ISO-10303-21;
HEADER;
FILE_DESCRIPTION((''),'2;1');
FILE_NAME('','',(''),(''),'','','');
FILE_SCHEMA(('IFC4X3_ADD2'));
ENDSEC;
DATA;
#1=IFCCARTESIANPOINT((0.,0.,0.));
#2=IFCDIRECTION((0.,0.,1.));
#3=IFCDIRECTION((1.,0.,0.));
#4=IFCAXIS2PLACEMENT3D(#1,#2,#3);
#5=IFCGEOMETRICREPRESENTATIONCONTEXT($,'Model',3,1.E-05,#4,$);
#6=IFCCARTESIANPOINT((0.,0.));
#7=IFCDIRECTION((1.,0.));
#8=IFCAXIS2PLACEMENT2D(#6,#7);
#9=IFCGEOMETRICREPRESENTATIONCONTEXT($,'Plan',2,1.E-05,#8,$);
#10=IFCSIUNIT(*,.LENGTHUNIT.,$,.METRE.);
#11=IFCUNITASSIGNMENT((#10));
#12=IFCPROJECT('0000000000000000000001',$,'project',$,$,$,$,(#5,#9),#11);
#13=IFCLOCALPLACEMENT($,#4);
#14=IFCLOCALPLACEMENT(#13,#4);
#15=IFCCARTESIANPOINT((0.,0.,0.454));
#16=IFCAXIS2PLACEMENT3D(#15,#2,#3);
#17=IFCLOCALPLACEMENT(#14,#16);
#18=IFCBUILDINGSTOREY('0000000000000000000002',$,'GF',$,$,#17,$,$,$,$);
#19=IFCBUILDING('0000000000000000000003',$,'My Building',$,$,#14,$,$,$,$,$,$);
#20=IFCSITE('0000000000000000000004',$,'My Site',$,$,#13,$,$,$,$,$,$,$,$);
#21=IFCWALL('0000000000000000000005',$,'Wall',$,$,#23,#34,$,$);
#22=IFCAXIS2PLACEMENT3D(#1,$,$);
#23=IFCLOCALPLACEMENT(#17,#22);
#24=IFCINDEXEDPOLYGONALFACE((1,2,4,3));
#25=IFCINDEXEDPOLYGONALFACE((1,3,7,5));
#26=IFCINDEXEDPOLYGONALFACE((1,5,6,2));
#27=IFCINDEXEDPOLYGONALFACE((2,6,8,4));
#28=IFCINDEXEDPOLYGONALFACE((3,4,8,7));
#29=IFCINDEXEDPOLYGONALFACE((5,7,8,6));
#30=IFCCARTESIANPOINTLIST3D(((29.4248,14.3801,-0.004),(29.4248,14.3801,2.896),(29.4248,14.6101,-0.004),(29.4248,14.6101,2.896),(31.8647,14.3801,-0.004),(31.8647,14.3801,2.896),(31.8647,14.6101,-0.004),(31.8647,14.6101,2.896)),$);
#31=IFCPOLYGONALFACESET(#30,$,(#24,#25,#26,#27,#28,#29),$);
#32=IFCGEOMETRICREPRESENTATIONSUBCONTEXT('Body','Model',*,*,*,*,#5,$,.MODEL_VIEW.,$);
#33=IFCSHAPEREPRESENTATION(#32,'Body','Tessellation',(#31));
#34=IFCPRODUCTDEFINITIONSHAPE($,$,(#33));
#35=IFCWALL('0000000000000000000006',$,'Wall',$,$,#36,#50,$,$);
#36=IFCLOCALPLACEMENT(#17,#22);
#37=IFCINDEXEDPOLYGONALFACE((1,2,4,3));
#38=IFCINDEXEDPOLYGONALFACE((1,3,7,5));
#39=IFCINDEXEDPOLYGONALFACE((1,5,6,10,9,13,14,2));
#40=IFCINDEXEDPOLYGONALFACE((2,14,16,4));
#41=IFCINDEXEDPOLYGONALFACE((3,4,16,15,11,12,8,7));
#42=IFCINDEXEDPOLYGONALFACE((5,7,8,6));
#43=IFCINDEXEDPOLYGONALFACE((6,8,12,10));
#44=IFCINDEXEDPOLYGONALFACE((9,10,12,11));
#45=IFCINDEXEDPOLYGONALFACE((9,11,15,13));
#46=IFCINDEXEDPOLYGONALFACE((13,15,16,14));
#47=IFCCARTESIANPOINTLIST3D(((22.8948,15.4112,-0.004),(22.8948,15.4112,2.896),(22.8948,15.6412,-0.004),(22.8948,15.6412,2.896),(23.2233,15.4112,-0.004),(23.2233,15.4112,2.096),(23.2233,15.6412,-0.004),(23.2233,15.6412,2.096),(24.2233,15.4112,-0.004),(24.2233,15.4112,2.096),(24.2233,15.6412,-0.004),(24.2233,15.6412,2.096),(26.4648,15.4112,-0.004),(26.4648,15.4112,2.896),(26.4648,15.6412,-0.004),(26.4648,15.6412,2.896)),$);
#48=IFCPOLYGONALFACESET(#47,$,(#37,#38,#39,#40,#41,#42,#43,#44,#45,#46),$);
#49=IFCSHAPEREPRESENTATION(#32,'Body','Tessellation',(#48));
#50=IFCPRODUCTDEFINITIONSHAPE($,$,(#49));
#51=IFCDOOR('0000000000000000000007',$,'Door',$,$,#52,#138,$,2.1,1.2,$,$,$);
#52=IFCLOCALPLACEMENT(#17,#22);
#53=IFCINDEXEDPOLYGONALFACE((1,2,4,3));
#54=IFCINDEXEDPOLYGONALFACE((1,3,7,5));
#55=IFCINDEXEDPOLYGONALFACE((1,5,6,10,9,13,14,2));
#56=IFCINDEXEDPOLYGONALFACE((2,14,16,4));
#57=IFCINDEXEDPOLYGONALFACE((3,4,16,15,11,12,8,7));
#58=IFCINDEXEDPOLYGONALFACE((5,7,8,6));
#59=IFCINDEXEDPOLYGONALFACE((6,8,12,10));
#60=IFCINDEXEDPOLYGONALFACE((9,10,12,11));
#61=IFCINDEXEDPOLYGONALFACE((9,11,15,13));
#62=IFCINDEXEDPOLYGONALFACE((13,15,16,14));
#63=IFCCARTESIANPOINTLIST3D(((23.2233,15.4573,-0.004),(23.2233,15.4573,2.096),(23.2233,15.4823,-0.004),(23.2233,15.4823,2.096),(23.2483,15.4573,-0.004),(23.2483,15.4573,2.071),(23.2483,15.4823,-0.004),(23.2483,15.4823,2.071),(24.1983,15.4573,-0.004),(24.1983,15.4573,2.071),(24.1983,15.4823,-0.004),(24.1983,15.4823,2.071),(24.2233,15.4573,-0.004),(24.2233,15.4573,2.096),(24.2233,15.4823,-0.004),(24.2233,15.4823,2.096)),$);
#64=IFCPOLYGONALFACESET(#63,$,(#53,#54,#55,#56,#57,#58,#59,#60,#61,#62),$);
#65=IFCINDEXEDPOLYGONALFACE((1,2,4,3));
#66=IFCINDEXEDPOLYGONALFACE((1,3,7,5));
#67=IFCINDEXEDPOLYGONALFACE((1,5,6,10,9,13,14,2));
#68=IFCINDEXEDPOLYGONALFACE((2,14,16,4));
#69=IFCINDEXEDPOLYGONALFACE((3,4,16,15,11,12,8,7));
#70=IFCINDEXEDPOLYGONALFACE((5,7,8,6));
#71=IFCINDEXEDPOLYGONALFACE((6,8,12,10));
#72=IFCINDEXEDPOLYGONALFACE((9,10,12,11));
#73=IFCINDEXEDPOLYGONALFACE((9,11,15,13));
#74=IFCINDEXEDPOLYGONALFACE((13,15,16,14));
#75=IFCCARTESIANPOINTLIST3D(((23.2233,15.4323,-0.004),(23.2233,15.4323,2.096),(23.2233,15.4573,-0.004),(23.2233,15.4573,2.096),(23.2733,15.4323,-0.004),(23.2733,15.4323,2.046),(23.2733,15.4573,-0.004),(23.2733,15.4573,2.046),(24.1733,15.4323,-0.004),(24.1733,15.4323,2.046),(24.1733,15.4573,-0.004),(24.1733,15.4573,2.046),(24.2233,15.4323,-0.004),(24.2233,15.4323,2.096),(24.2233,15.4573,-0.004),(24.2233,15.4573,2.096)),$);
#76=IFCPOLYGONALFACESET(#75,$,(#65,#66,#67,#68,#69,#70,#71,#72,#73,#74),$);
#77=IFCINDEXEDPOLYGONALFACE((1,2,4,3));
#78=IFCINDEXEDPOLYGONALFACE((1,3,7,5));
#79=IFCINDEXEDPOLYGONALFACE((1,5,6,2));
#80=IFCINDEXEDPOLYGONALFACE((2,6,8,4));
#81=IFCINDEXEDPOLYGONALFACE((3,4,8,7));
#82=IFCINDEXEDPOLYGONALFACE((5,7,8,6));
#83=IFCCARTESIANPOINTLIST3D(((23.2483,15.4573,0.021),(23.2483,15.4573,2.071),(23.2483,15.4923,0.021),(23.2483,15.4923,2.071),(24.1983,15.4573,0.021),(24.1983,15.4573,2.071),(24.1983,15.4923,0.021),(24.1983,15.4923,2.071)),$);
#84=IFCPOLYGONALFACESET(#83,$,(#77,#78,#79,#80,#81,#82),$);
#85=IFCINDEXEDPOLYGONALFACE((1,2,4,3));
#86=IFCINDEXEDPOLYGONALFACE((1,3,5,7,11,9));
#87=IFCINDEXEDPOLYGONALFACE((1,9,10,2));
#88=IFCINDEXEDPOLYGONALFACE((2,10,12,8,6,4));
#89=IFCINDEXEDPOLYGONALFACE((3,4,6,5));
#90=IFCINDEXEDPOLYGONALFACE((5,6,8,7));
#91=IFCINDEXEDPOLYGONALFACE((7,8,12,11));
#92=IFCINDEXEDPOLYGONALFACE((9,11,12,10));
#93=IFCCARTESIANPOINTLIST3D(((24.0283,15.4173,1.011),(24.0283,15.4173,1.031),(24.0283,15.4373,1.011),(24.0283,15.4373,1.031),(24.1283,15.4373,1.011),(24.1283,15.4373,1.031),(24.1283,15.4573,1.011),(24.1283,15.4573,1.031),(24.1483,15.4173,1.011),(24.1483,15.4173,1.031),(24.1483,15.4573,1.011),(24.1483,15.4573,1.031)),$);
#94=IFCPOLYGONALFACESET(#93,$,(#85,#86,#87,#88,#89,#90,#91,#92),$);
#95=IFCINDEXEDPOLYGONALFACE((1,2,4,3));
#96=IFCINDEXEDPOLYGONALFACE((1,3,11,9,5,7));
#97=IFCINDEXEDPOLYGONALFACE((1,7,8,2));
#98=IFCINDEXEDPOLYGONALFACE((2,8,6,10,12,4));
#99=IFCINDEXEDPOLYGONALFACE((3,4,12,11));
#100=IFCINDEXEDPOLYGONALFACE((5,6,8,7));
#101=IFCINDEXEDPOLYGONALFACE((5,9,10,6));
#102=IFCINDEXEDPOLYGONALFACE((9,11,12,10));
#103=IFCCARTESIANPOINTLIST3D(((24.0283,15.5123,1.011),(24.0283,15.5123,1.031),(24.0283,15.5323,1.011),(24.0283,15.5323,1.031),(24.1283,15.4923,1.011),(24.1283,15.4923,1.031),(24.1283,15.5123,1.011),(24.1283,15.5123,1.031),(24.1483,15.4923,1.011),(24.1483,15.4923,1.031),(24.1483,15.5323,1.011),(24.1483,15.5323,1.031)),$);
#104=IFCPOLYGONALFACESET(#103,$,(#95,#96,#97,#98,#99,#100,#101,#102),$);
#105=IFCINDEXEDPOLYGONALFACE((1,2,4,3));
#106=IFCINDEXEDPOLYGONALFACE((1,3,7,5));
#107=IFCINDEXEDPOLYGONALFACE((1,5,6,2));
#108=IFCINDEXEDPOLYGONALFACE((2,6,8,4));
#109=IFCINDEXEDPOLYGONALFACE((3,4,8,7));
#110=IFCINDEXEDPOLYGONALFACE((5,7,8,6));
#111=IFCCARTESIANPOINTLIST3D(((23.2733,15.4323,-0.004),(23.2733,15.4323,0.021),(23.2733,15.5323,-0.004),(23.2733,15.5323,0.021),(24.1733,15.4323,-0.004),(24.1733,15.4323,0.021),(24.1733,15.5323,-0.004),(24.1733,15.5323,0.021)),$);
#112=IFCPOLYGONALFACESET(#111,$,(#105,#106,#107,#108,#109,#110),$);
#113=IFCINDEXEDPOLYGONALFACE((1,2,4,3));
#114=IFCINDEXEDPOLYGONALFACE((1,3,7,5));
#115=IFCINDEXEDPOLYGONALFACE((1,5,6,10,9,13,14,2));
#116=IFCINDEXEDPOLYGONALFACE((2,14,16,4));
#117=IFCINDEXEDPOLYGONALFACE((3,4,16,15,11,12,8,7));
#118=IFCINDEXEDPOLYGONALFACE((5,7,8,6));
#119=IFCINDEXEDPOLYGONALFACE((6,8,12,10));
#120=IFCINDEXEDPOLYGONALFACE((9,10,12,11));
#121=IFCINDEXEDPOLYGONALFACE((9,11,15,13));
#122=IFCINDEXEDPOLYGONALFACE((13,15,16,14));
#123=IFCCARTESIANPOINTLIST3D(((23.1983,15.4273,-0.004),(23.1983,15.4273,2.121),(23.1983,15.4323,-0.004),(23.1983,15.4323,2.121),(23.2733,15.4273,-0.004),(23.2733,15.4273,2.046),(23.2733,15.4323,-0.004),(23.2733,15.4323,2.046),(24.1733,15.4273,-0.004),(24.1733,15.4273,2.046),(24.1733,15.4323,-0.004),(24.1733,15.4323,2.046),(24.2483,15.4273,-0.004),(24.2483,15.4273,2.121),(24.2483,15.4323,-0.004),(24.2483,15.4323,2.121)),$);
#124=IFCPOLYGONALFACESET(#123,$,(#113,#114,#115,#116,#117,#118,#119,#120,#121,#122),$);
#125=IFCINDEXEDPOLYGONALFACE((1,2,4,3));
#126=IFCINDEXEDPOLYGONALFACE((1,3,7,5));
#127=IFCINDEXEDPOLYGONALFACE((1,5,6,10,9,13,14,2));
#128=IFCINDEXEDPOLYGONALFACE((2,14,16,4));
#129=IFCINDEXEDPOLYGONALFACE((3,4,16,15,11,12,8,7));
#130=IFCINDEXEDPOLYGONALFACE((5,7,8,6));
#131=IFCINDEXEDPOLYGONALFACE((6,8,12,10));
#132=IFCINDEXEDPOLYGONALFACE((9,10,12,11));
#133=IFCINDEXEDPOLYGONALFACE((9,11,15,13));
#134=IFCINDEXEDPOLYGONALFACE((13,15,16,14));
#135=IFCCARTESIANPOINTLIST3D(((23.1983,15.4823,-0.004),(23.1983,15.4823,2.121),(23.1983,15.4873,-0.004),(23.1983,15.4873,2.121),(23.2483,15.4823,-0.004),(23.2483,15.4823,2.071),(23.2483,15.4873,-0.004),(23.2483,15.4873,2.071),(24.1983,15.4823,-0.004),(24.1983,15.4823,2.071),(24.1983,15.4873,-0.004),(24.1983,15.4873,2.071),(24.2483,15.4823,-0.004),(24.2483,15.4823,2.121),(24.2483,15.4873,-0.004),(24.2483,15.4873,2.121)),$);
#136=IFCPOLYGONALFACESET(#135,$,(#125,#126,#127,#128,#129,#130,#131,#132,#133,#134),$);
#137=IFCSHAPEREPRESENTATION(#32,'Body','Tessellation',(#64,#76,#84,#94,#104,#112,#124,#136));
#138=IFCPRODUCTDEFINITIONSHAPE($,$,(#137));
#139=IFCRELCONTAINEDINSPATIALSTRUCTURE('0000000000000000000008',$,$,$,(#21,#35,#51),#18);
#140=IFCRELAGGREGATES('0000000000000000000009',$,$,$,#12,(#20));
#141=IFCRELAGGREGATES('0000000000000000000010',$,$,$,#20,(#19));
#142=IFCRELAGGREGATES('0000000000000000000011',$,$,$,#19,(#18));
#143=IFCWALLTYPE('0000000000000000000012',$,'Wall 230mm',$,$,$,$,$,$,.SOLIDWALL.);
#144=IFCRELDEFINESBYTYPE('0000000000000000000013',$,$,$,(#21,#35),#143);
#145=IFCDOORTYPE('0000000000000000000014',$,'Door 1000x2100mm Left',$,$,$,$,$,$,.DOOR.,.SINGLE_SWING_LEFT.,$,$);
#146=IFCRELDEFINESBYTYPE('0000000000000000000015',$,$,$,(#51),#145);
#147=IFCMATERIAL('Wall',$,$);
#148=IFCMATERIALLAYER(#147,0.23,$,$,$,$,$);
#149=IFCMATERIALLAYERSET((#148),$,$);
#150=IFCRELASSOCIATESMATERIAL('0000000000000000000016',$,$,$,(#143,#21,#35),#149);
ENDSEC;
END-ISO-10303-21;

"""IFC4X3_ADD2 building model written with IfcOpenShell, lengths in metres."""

from ifc_helpers import new_model, entity, si_unit, frame, origin_with_axes, origin_2d_with_axis, place, context, subcontext, project, spatial, line, indexed_curve, outline, extrude, shape, source, transform, mapped, material, layer, layer_set, layer_usage, type_object, type_shapes, element, fill, save


model = new_model("IFC4X3_ADD2")

# Units and contexts
model_context = context("Model", 3, precision=1e-05, world=origin_with_axes())
plan_context = context("Plan", 2, precision=1e-05, world=origin_2d_with_axis())
body_context_1 = subcontext(model_context, "Body", "Model", "MODEL_VIEW")
body_context_2 = subcontext(plan_context, "Body", "Plan", "PLAN_VIEW")
ifc_project = project(units=[si_unit("LENGTHUNIT", "METRE")], contexts=[model_context, plan_context])

# Site, building, storey
site_placement = place(None, origin_with_axes())
site = spatial("IfcSite", under=ifc_project, at=site_placement, Name="My Site")
building_placement = place(site_placement, origin_with_axes())
building = spatial("IfcBuilding", under=site, at=building_placement, Name="My Building")
storey_placement = place(building_placement, frame((0.0, 0.0, 0.454), z_axis=(0.0, 0.0, 1.0), x_axis=(1.0, 0.0, 0.0)))
storey = spatial("IfcBuildingStorey", under=building, at=storey_placement, Name="GF")

# Shared definitions
ifc_material_1 = material(Name="Wall")

# Shared definitions
ifc_layer_1 = layer(ifc_material_1, 0.23)
ifc_layer_set_1 = layer_set([ifc_layer_1])
wall_type_1 = type_object("IfcWallType", Name="Wall 230mm", PredefinedType="SOLIDWALL", material=ifc_layer_set_1)

# Wall
ifc_layer_usage_1 = layer_usage(ifc_layer_set_1, "AXIS2", "POSITIVE", 0.0)
wall_1_placement = place(storey_placement, frame((31.8647, 14.6101, -0.004), z_axis=(0.0, 0.0, 1.0), x_axis=(-1.0, 0.0, 0.0)))
element("IfcWall", 1, at=wall_1_placement, inside=storey, type_object=wall_type_1, material=ifc_layer_usage_1, Name="Wall", context=body_context_1, shape_type="SweptSolid", body=[
    extrude(outline(indexed_curve([(0.0, 0.0), (0.0, 0.23), (2.44, 0.23), (2.44, 0.0), (0.0, 0.0)], self_intersect=False)), origin_with_axes(), (0.0, 0.0, 1.0), 2.9),
])

# Wall, opening, door
ifc_layer_usage_2 = layer_usage(ifc_layer_set_1, "AXIS2", "POSITIVE", 0.0)
wall_2_placement = place(storey_placement, frame((26.4648, 15.6412, -0.004), z_axis=(0.0, 0.0, 1.0), x_axis=(-1.0, 0.0, 0.0)))
wall_2 = element("IfcWall", 2, at=wall_2_placement, inside=storey, type_object=wall_type_1, material=ifc_layer_usage_2, Name="Wall", context=body_context_1, shape_type="SweptSolid", body=[
    extrude(outline(indexed_curve([(0.0, 0.0), (0.0, 0.23), (3.57, 0.23), (3.57, 0.0), (0.0, 0.0)], self_intersect=False)), origin_with_axes(), (0.0, 0.0, 1.0), 2.9),
])
shared_shape_1 = source(origin_with_axes(), body_context_1, "Body", "SweptSolid", [
    extrude(outline(indexed_curve([(0.0, 0.0), (1.0, 0.0), (1.0, 2.1), (0.0, 2.1)], segments=[line(1, 2, 3, 4, 1)])), frame((0.0, -0.6, 0.0), z_axis=(0.0, -1.0, 0.0), x_axis=(1.0, 0.0, 0.0)), (0.0, 0.0, -1.0), 1.2),
])
opening_1_placement = place(wall_2_placement, frame((3.2415, 0.209, 0.0), z_axis=(0.0, 0.0, 1.0), x_axis=(-1.0, 0.0, 0.0)))
opening_1 = element("IfcOpeningElement", 3, at=opening_1_placement, cuts=wall_2, PredefinedType="OPENING", context=body_context_1, shape_type="MappedRepresentation", body=[
    mapped(shared_shape_1, transform((0.0, 0.0, 0.0), x_axis=(1.0, 0.0, 0.0), y_axis=(0.0, 1.0, 0.0), z_axis=(0.0, 0.0, 1.0), scale=1.0)),
])
door_type_1 = type_object("IfcDoorType", Name="Door 1000x2100mm Left", OperationType="SINGLE_SWING_LEFT", PredefinedType="DOOR")
shared_shape_2 = source(origin_with_axes(), body_context_1, "Body", "SweptSolid", [
    extrude(outline(indexed_curve([(0.0, 0.0), (0.0, 2.1), (1.0, 2.1), (1.0, 0.0), (0.975, 0.0), (0.975, 2.075), (0.025, 2.075), (0.025, 0.0)], segments=[line(1, 2, 3, 4, 5, 6, 7, 8, 1)])), frame((0.0, 0.025, 0.0), z_axis=(0.0, -1.0, 0.0), x_axis=(1.0, 0.0, 0.0)), (0.0, 0.0, -1.0), 0.025),
    extrude(outline(indexed_curve([(0.0, 0.0), (0.0, 2.1), (1.0, 2.1), (1.0, 0.0), (0.95, 0.0), (0.95, 2.05), (0.05, 2.05), (0.05, 0.0)], segments=[line(1, 2, 3, 4, 5, 6, 7, 8, 1)])), frame((0.0, 0.0, 0.0), z_axis=(0.0, -1.0, 0.0), x_axis=(1.0, 0.0, 0.0)), (0.0, 0.0, -1.0), 0.025),
    extrude(outline(indexed_curve([(0.0, 0.0), (0.95, 0.0), (0.95, 0.035), (0.0, 0.035)], segments=[line(1, 2, 3, 4, 1)])), frame((0.025, 0.025, 0.025), z_axis=(0.0, 0.0, 1.0), x_axis=(1.0, 0.0, 0.0)), (0.0, 0.0, 1.0), 2.05),
    extrude(outline(indexed_curve([(0.0, 0.0), (0.0, -0.04), (-0.12, -0.04), (-0.12, -0.02), (-0.02, -0.02), (-0.02, 0.0)], segments=[line(1, 2, 3, 4, 5, 6, 1)])), frame((0.925, 0.025, 1.015), z_axis=(0.0, 0.0, 1.0), x_axis=(1.0, 0.0, 0.0)), (0.0, 0.0, 1.0), 0.02),
    extrude(outline(indexed_curve([(0.0, 0.0), (0.0, 0.04), (-0.12, 0.04), (-0.12, 0.02), (-0.02, 0.02), (-0.02, 0.0)], segments=[line(1, 2, 3, 4, 5, 6, 1)])), frame((0.925, 0.06, 1.015), z_axis=(0.0, 0.0, 1.0), x_axis=(1.0, 0.0, 0.0)), (0.0, 0.0, 1.0), 0.02),
    extrude(outline(indexed_curve([(0.0, 0.0), (0.9, 0.0), (0.9, 0.1), (0.0, 0.1)], segments=[line(1, 2, 3, 4, 1)])), frame((0.05, 0.0, 0.0), z_axis=(0.0, 0.0, 1.0), x_axis=(1.0, 0.0, 0.0)), (0.0, 0.0, 1.0), 0.025),
    extrude(outline(indexed_curve([(0.0, 0.0), (0.0, 2.125), (1.05, 2.125), (1.05, 0.0), (0.975, 0.0), (0.975, 2.05), (0.075, 2.05), (0.075, 0.0)], segments=[line(1, 2, 3, 4, 5, 6, 7, 8, 1)])), frame((-0.025, -0.005, 0.0), z_axis=(0.0, -1.0, 0.0), x_axis=(1.0, 0.0, 0.0)), (0.0, 0.0, -1.0), 0.005),
    extrude(outline(indexed_curve([(0.0, 0.0), (0.0, 2.125), (1.05, 2.125), (1.05, 0.0), (1.0, 0.0), (1.0, 2.075), (0.05, 2.075), (0.05, 0.0)], segments=[line(1, 2, 3, 4, 5, 6, 7, 8, 1)])), frame((-0.025, 0.05, 0.0), z_axis=(0.0, -1.0, 0.0), x_axis=(1.0, 0.0, 0.0)), (0.0, 0.0, -1.0), 0.005),
])
shared_shape_3 = source(origin_with_axes(), body_context_2, "Body", "Curve2D", [
    entity("IfcIndexedPolyCurve", entity("IfcCartesianPointList2D", [[0.0, 0.0], [0.0, 0.05], [0.025, 0.05], [0.025, 0.025], [0.05, 0.025], [0.05, 0.0]]), [entity("IfcLineIndex", [1, 2, 3, 4, 5, 6, 1])]),
    entity("IfcIndexedPolyCurve", entity("IfcCartesianPointList2D", [[1.0, 0.0], [1.0, 0.05], [0.975, 0.05], [0.975, 0.025], [0.95, 0.025], [0.95, 0.0]]), [entity("IfcLineIndex", [1, 2, 3, 4, 5, 6, 1])]),
    entity("IfcTrimmedCurve", entity("IfcEllipse", entity("IfcAxis2Placement2D", entity("IfcCartesianPoint", [0.06, 0.05]), entity("IfcDirection", [1.0, 0.0])), 0.915, 0.95), [entity("IfcCartesianPoint", [0.975, 0.05])], [entity("IfcCartesianPoint", [0.06, 1.0])], True, "CARTESIAN"),
    entity("IfcIndexedPolyCurve", entity("IfcCartesianPointList2D", [[0.025, 0.05], [0.06, 0.05], [0.06, 1.0], [0.025, 1.0]]), [entity("IfcLineIndex", [1, 2, 3, 4, 1])]),
])
type_shapes(door_type_1, [shared_shape_2, shared_shape_3])
door_1_placement = place(opening_1_placement, frame((0.0, 0.0, 0.0), z_axis=(0.0, 0.0, 1.0), x_axis=(1.0, 0.0, 0.0)))
door_1 = element("IfcDoor", 4, at=door_1_placement, inside=storey, type_object=door_type_1, Name="Door", OverallHeight=2.1, OverallWidth=1.2, shapes=[
    shape(body_context_1, "Body", "MappedRepresentation", [mapped(shared_shape_2, transform((0.0, 0.0, 0.0), x_axis=(1.0, 0.0, 0.0), y_axis=(0.0, 1.0, 0.0), z_axis=(0.0, 0.0, 1.0), scale=1.0))]),
    shape(body_context_2, "Body", "MappedRepresentation", [mapped(shared_shape_3, transform((0.0, 0.0, 0.0), x_axis=(1.0, 0.0, 0.0), y_axis=(0.0, 1.0, 0.0), z_axis=(0.0, 0.0, 1.0), scale=1.0))]),
])
fill(opening_1, door_1)

save(model, "model.ifc")
